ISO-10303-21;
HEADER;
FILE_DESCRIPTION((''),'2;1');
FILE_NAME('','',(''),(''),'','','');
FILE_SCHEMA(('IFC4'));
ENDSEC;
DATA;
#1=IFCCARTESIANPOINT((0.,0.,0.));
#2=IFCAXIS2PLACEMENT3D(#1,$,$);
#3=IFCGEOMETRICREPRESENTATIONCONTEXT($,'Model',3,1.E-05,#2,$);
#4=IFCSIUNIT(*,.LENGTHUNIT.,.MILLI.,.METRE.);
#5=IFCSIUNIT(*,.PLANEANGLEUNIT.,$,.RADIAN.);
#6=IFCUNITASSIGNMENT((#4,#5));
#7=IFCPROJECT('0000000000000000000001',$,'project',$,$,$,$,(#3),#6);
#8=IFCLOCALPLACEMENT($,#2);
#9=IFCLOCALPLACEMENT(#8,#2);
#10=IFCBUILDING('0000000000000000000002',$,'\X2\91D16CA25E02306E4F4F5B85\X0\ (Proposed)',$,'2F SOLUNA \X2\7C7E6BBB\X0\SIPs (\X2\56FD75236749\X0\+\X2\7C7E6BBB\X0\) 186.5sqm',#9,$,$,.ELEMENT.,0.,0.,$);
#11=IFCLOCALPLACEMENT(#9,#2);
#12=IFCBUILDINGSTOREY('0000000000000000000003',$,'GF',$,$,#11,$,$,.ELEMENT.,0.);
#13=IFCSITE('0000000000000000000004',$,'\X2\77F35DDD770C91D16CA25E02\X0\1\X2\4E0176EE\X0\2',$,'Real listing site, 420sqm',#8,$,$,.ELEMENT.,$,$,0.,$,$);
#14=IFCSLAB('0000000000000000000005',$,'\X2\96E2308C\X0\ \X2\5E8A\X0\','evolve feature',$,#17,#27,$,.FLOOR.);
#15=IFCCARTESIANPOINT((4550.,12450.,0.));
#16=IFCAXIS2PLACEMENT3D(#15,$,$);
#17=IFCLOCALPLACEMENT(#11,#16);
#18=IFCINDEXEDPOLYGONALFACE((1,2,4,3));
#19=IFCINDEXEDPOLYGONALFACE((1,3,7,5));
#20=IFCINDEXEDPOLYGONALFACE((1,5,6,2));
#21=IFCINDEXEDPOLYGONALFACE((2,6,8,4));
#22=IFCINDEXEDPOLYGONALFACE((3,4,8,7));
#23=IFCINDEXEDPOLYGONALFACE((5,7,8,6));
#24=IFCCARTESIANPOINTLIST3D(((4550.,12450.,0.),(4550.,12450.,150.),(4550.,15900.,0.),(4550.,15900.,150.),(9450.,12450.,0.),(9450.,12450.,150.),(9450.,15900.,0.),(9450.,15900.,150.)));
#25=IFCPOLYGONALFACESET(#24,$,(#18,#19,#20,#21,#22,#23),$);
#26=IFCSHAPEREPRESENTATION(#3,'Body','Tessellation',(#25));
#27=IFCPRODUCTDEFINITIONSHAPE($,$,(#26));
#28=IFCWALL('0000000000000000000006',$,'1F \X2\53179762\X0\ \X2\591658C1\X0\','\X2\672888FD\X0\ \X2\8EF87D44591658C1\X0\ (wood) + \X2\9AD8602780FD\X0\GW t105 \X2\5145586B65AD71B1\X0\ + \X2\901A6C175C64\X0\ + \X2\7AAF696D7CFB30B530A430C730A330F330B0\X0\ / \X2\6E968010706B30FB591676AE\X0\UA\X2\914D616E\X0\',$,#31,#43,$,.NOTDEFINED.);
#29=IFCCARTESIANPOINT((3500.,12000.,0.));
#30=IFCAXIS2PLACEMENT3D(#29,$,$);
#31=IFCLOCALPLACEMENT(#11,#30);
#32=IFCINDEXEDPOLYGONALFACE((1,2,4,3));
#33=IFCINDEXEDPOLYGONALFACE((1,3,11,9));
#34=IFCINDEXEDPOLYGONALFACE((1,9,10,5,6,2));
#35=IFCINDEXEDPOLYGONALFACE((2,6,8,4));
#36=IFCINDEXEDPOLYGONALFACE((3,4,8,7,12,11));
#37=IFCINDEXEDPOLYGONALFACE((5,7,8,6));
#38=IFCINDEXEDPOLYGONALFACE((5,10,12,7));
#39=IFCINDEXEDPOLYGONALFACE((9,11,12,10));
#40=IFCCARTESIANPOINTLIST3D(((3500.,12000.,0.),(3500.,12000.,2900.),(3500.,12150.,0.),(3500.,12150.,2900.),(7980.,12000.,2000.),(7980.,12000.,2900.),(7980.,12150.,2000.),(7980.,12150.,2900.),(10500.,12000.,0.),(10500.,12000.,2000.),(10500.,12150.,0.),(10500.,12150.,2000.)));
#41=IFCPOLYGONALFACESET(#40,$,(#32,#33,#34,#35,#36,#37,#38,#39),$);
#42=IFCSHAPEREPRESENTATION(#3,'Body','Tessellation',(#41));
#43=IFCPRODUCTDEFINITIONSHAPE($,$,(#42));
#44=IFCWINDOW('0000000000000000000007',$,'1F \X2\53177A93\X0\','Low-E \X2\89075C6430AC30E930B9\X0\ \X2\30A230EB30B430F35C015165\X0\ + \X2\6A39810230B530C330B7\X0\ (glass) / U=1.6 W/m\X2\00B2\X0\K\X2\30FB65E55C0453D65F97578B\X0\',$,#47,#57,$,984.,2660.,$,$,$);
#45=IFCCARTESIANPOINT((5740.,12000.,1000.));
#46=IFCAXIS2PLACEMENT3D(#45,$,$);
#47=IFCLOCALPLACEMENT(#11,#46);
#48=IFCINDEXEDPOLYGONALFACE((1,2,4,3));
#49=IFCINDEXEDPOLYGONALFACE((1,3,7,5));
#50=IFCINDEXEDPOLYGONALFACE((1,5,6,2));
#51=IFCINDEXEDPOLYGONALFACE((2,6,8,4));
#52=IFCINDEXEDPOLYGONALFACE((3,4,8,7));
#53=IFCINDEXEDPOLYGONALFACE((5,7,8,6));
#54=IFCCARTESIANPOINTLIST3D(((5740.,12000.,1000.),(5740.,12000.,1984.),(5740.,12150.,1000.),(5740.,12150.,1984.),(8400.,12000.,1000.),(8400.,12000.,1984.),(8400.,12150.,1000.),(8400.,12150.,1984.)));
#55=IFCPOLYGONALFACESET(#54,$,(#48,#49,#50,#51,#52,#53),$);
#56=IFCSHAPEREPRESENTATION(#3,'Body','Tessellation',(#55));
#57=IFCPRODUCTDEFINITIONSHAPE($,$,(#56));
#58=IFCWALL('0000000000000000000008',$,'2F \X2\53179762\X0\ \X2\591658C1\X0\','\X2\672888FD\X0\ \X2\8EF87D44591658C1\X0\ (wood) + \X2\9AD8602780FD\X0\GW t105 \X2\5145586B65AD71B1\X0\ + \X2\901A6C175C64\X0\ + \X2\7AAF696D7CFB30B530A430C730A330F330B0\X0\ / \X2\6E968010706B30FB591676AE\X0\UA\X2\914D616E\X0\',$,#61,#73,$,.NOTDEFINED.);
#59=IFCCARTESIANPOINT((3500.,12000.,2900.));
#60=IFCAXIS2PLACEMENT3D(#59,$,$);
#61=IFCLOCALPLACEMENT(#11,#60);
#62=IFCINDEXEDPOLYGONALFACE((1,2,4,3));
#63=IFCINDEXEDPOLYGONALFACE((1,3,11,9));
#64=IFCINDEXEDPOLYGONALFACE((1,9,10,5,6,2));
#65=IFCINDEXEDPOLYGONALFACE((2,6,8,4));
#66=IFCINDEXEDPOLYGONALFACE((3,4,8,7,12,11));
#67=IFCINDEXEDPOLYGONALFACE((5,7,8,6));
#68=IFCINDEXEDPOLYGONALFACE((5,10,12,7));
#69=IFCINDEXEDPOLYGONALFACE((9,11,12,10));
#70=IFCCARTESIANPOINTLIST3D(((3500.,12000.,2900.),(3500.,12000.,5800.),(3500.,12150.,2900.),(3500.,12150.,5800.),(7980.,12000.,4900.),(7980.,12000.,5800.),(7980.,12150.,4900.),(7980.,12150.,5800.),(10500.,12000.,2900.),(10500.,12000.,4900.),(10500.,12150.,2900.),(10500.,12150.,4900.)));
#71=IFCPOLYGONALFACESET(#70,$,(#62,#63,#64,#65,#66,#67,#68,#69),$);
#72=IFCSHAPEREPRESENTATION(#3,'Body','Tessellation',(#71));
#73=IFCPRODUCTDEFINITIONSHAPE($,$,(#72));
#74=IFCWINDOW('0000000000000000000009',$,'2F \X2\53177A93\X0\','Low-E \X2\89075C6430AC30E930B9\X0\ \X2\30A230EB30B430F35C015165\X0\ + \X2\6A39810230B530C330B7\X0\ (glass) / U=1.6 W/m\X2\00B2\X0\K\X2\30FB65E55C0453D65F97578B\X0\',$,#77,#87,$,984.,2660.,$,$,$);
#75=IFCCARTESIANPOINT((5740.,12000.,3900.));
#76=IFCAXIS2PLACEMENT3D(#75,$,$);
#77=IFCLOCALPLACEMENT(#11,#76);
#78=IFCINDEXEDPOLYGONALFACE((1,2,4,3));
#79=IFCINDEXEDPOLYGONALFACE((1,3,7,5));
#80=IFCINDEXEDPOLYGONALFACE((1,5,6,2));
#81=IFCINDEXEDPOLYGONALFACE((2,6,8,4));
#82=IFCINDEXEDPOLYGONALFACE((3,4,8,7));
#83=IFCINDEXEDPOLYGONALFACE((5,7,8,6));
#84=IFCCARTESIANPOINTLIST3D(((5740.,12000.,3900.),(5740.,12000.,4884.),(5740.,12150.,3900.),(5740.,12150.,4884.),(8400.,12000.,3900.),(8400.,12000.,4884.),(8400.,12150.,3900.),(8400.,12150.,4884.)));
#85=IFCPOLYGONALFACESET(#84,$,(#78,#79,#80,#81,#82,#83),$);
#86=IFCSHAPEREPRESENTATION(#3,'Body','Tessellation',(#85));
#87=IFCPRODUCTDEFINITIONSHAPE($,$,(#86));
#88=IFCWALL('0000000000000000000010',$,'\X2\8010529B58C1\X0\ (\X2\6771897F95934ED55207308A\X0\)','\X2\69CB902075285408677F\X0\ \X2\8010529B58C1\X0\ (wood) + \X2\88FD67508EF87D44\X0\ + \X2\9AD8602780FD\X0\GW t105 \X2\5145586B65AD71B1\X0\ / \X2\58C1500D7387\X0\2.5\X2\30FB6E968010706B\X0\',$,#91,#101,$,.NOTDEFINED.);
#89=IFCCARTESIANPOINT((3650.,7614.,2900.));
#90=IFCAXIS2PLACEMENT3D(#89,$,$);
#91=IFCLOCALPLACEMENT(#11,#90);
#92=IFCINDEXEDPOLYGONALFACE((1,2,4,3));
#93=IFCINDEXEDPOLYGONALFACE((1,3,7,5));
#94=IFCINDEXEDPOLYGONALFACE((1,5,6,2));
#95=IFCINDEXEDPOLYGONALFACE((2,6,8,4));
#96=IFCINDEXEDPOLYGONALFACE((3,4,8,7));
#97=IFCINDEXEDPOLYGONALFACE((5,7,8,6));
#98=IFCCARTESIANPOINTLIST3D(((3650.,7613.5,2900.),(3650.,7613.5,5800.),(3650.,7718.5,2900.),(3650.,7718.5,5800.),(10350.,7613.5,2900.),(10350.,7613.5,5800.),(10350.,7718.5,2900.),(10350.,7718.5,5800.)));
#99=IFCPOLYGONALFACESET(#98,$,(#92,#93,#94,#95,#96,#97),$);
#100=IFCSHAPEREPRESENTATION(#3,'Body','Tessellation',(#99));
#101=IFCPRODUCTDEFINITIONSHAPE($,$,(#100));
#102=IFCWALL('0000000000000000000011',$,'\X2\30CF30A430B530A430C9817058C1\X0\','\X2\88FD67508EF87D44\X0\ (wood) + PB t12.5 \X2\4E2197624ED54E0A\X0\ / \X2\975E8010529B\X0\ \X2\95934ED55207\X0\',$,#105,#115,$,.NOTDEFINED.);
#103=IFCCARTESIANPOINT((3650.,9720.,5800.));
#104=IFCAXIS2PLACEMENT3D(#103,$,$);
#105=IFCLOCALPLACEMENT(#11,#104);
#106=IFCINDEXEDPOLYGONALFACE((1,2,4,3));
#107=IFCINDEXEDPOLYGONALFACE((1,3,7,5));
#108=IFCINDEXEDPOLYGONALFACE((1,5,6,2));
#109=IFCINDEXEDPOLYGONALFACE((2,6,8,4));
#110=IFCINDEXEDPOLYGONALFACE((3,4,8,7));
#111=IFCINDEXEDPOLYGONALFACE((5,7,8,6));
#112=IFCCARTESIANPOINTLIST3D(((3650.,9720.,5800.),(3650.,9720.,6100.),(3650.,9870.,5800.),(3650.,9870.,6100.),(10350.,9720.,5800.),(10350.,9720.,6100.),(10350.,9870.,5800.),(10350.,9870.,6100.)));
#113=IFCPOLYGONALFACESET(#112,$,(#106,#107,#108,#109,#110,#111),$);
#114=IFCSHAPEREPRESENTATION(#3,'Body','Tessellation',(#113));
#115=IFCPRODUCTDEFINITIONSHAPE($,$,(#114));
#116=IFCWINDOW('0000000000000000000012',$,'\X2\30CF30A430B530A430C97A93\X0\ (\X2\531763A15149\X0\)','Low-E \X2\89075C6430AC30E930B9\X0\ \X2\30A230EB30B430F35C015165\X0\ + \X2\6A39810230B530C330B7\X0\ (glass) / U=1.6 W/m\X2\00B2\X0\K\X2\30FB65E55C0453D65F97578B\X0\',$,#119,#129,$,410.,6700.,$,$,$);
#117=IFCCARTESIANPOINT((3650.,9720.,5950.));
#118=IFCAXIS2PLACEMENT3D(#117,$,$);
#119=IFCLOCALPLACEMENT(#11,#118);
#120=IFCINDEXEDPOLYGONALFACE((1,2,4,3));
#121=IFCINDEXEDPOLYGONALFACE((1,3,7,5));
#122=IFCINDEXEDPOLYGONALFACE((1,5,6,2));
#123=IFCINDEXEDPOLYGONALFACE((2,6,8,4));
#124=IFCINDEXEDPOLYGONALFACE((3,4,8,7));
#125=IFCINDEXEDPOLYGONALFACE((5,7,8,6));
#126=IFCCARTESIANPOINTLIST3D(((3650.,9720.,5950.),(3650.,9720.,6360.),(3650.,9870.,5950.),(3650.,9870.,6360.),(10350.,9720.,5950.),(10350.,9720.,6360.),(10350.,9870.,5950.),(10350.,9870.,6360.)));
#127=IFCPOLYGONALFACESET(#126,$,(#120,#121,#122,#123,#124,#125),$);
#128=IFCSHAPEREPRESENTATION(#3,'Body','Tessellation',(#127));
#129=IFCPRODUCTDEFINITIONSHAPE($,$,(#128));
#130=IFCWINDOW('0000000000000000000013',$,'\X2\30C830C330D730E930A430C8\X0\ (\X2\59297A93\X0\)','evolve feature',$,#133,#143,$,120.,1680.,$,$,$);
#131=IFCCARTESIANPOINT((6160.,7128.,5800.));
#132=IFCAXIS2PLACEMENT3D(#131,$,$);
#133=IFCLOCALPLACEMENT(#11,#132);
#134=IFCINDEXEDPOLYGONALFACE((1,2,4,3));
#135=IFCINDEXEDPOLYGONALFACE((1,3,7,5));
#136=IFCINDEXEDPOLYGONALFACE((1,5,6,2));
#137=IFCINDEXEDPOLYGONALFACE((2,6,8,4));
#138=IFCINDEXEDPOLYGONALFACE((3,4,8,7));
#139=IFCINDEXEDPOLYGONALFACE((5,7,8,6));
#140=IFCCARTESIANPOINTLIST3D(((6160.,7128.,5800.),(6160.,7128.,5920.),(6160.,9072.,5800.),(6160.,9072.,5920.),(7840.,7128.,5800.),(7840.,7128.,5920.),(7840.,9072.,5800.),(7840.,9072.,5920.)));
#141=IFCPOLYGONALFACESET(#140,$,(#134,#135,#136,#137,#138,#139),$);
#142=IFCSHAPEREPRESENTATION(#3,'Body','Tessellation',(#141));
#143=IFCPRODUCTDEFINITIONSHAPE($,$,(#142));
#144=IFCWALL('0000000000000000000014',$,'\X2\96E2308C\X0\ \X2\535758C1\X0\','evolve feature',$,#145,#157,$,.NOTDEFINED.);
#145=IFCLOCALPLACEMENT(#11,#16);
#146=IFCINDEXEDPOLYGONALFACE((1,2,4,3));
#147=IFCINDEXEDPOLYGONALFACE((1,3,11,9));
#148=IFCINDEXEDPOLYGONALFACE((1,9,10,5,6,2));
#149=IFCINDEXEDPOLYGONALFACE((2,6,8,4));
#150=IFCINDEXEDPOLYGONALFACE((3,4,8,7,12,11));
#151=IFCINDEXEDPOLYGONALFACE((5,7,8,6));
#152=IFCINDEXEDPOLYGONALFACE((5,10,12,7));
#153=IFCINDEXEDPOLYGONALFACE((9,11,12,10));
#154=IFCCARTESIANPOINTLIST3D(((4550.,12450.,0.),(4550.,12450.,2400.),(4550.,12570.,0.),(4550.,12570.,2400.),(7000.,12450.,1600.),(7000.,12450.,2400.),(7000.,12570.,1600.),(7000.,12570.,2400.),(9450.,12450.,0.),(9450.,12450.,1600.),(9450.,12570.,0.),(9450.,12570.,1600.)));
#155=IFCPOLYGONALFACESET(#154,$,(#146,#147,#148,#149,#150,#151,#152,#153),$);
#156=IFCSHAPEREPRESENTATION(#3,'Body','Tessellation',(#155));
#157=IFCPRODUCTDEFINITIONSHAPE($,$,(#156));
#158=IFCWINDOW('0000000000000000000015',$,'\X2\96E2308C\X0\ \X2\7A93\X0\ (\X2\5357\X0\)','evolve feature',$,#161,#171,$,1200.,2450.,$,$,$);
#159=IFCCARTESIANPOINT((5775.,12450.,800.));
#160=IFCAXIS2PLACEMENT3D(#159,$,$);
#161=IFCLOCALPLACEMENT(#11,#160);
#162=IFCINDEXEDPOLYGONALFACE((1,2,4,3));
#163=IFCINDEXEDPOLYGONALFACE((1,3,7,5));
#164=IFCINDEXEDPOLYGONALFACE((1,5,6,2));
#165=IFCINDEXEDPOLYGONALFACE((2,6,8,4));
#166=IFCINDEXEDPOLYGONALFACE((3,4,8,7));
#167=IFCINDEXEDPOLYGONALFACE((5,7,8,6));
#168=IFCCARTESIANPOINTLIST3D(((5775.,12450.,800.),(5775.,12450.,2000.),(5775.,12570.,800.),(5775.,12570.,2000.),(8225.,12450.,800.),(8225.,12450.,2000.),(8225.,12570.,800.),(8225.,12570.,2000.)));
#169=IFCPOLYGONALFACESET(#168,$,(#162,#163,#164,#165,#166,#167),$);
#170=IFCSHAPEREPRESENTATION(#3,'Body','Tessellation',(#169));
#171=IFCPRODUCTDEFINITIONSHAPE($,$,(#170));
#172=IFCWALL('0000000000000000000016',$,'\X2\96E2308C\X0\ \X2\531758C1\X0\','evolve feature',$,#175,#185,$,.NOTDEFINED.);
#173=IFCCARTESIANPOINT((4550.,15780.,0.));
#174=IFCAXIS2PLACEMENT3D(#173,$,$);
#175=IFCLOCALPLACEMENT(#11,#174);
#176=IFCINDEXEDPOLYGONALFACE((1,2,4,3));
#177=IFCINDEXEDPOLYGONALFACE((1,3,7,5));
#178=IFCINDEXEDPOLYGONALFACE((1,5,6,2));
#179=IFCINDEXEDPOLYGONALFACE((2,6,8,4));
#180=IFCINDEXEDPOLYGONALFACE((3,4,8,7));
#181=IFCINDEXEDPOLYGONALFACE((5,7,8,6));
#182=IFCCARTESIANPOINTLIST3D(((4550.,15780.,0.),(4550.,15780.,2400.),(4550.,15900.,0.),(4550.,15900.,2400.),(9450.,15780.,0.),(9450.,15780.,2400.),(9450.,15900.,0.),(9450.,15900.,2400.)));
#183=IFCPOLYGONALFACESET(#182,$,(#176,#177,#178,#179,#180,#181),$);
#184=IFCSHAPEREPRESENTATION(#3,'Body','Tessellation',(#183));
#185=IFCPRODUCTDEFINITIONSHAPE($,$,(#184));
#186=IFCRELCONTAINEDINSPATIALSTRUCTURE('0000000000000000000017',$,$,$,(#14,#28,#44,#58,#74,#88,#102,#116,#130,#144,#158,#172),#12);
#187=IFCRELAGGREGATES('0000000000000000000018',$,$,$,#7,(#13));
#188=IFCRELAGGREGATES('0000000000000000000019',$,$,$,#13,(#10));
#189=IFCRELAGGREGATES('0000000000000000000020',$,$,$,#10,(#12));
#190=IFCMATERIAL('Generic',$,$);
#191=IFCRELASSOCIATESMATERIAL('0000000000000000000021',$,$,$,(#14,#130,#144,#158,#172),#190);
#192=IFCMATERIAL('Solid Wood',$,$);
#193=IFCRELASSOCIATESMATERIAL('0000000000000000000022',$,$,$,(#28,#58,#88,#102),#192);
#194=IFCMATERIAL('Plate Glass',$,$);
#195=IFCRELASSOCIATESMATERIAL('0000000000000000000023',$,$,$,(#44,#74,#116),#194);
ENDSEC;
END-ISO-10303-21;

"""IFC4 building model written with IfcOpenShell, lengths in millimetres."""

from ifc_helpers import new_model, si_unit, frame, frame_2d, origin, place, context, project, spatial, rectangle, extrude, material, element, fill, save


model = new_model("IFC4")

# Units and contexts
model_context = context("Model", 3, precision=1e-05, world=origin())
ifc_project = project(units=[si_unit("LENGTHUNIT", "METRE", prefix="MILLI"), si_unit("PLANEANGLEUNIT", "RADIAN")], contexts=[model_context])

# Site, building, storey
site_placement = place(None, origin())
site = spatial("IfcSite", under=ifc_project, at=site_placement, Name="石川県金沢市1丁目2", ObjectType="Real listing site, 420sqm", CompositionType="ELEMENT", RefElevation=0.0)
building_placement = place(site_placement, origin())
building = spatial("IfcBuilding", under=site, at=building_placement, Name="金沢市の住宅 (Proposed)", ObjectType="2F SOLUNA 籾殻SIPs (国産杉+籾殻) 186.5sqm", CompositionType="ELEMENT", ElevationOfRefHeight=0.0, ElevationOfTerrain=0.0)
storey_placement = place(building_placement, origin())
storey = spatial("IfcBuildingStorey", under=building, at=storey_placement, Name="GF", CompositionType="ELEMENT", Elevation=0.0)

# Slab
ifc_material_1 = material(Name="Generic")
slab_placement = place(storey_placement, frame((4550.0, 12450.0, 0.0)))
element("IfcSlab", 1, at=slab_placement, inside=storey, material=ifc_material_1, Name="離れ 床", Description="evolve feature", PredefinedType="FLOOR", context=model_context, shape_type="SweptSolid", body=[
    extrude(rectangle(XDim=4900.0, YDim=3450.0, at=frame_2d((2450.0, 1725.0))), frame((4550.0, 12450.0, 0.0)), (0.0, 0.0, 1.0), 150.0),
])

# Wall, opening, window
ifc_material_2 = material(Name="Solid Wood")
wall_1_placement = place(storey_placement, frame((3500.0, 12000.0, 0.0)))
wall_1 = element("IfcWall", 2, at=wall_1_placement, inside=storey, material=ifc_material_2, Name="1F 北面 外壁", Description="木製 軸組外壁 (wood) + 高性能GW t105 充填断熱 + 通気層 + 窯業系サイディング / 準耐火・外皮UA配慮", PredefinedType="NOTDEFINED", context=model_context, shape_type="SweptSolid", body=[
    extrude(rectangle(XDim=7000.0, YDim=150.0, at=frame_2d((3500.0, 75.0))), frame((3500.0, 12000.0, 0.0)), (0.0, 0.0, 1.0), 2900.0),
])
opening_1_placement = place(storey_placement, frame((5740.0, 12000.0, 1000.0)))
opening_1 = element("IfcOpeningElement", 3, at=opening_1_placement, cuts=wall_1, PredefinedType="NOTDEFINED", context=model_context, shape_type="SweptSolid", body=[
    extrude(rectangle(XDim=2660.0, YDim=150.0, at=frame_2d((1330.0, 75.0))), frame((5740.0, 12000.0, 1000.0)), (0.0, 0.0, 1.0), 984.0),
])
ifc_material_3 = material(Name="Plate Glass")
window_1_placement = place(storey_placement, frame((5740.0, 12000.0, 1000.0)))
window_1 = element("IfcWindow", 4, at=window_1_placement, inside=storey, material=ifc_material_3, Name="1F 北窓", Description="Low-E 複層ガラス アルゴン封入 + 樹脂サッシ (glass) / U=1.6 W/m²K・日射取得型", OverallHeight=984.0, OverallWidth=2660.0, context=model_context, shape_type="SweptSolid", body=[
    extrude(rectangle(XDim=2660.0, YDim=150.0, at=frame_2d((1330.0, 75.0))), frame((5740.0, 12000.0, 1000.0)), (0.0, 0.0, 1.0), 984.0),
])
fill(opening_1, window_1)

# Wall, opening, window
wall_2_placement = place(storey_placement, frame((3500.0, 12000.0, 2900.0)))
wall_2 = element("IfcWall", 5, at=wall_2_placement, inside=storey, material=ifc_material_2, Name="2F 北面 外壁", Description="木製 軸組外壁 (wood) + 高性能GW t105 充填断熱 + 通気層 + 窯業系サイディング / 準耐火・外皮UA配慮", PredefinedType="NOTDEFINED", context=model_context, shape_type="SweptSolid", body=[
    extrude(rectangle(XDim=7000.0, YDim=150.0, at=frame_2d((3500.0, 75.0))), frame((3500.0, 12000.0, 2900.0)), (0.0, 0.0, 1.0), 2900.0),
])
opening_2_placement = place(storey_placement, frame((5740.0, 12000.0, 3900.0)))
opening_2 = element("IfcOpeningElement", 6, at=opening_2_placement, cuts=wall_2, PredefinedType="NOTDEFINED", context=model_context, shape_type="SweptSolid", body=[
    extrude(rectangle(XDim=2660.0, YDim=150.0, at=frame_2d((1330.0, 75.0))), frame((5740.0, 12000.0, 3900.0)), (0.0, 0.0, 1.0), 984.0),
])
window_2_placement = place(storey_placement, frame((5740.0, 12000.0, 3900.0)))
window_2 = element("IfcWindow", 7, at=window_2_placement, inside=storey, material=ifc_material_3, Name="2F 北窓", Description="Low-E 複層ガラス アルゴン封入 + 樹脂サッシ (glass) / U=1.6 W/m²K・日射取得型", OverallHeight=984.0, OverallWidth=2660.0, context=model_context, shape_type="SweptSolid", body=[
    extrude(rectangle(XDim=2660.0, YDim=150.0, at=frame_2d((1330.0, 75.0))), frame((5740.0, 12000.0, 3900.0)), (0.0, 0.0, 1.0), 984.0),
])
fill(opening_2, window_2)

# Wall
wall_3_placement = place(storey_placement, frame((3650.0, 7614.0, 2900.0)))
element("IfcWall", 8, at=wall_3_placement, inside=storey, material=ifc_material_2, Name="耐力壁 (東西間仕切り)", Description="構造用合板 耐力壁 (wood) + 製材軸組 + 高性能GW t105 充填断熱 / 壁倍率2.5・準耐火", PredefinedType="NOTDEFINED", context=model_context, shape_type="SweptSolid", body=[
    extrude(rectangle(XDim=6700.0, YDim=105.0, at=frame_2d((3350.0, 52.0))), frame((3650.0, 7614.0, 2900.0)), (0.0, 0.0, 1.0), 2900.0),
])

# Wall, opening, window
wall_4_placement = place(storey_placement, frame((3650.0, 9720.0, 5800.0)))
wall_4 = element("IfcWall", 9, at=wall_4_placement, inside=storey, material=ifc_material_2, Name="ハイサイド腰壁", Description="製材軸組 (wood) + PB t12.5 両面仕上 / 非耐力 間仕切", PredefinedType="NOTDEFINED", context=model_context, shape_type="SweptSolid", body=[
    extrude(rectangle(XDim=6700.0, YDim=150.0, at=frame_2d((3350.0, 75.0))), frame((3650.0, 9720.0, 5800.0)), (0.0, 0.0, 1.0), 700.0),
])
opening_3_placement = place(storey_placement, frame((3650.0, 9720.0, 5950.0)))
opening_3 = element("IfcOpeningElement", 10, at=opening_3_placement, cuts=wall_4, PredefinedType="NOTDEFINED", context=model_context, shape_type="SweptSolid", body=[
    extrude(rectangle(XDim=6700.0, YDim=150.0, at=frame_2d((3350.0, 75.0))), frame((3650.0, 9720.0, 5950.0)), (0.0, 0.0, 1.0), 410.0),
])
window_3_placement = place(storey_placement, frame((3650.0, 9720.0, 5950.0)))
window_3 = element("IfcWindow", 11, at=window_3_placement, inside=storey, material=ifc_material_3, Name="ハイサイド窓 (北採光)", Description="Low-E 複層ガラス アルゴン封入 + 樹脂サッシ (glass) / U=1.6 W/m²K・日射取得型", OverallHeight=410.0, OverallWidth=6700.0, context=model_context, shape_type="SweptSolid", body=[
    extrude(rectangle(XDim=6700.0, YDim=150.0, at=frame_2d((3350.0, 75.0))), frame((3650.0, 9720.0, 5950.0)), (0.0, 0.0, 1.0), 410.0),
])
fill(opening_3, window_3)

# Window
window_4_placement = place(storey_placement, frame((6160.0, 7128.0, 5800.0)))
element("IfcWindow", 12, at=window_4_placement, inside=storey, material=ifc_material_1, Name="トップライト (天窓)", Description="evolve feature", OverallHeight=120.0, OverallWidth=1680.0, context=model_context, shape_type="SweptSolid", body=[
    extrude(rectangle(XDim=1680.0, YDim=1944.0, at=frame_2d((840.0, 972.0))), frame((6160.0, 7128.0, 5800.0)), (0.0, 0.0, 1.0), 120.0),
])

# Wall, opening, window
wall_5_placement = place(storey_placement, frame((4550.0, 12450.0, 0.0)))
wall_5 = element("IfcWall", 13, at=wall_5_placement, inside=storey, material=ifc_material_1, Name="離れ 南壁", Description="evolve feature", PredefinedType="NOTDEFINED", context=model_context, shape_type="SweptSolid", body=[
    extrude(rectangle(XDim=4900.0, YDim=120.0, at=frame_2d((2450.0, 60.0))), frame((4550.0, 12450.0, 0.0)), (0.0, 0.0, 1.0), 2400.0),
])
opening_4_placement = place(storey_placement, frame((5775.0, 12450.0, 800.0)))
opening_4 = element("IfcOpeningElement", 14, at=opening_4_placement, cuts=wall_5, PredefinedType="NOTDEFINED", context=model_context, shape_type="SweptSolid", body=[
    extrude(rectangle(XDim=2450.0, YDim=120.0, at=frame_2d((1225.0, 60.0))), frame((5775.0, 12450.0, 800.0)), (0.0, 0.0, 1.0), 1200.0),
])
window_5_placement = place(storey_placement, frame((5775.0, 12450.0, 800.0)))
window_5 = element("IfcWindow", 15, at=window_5_placement, inside=storey, material=ifc_material_1, Name="離れ 窓 (南)", Description="evolve feature", OverallHeight=1200.0, OverallWidth=2450.0, context=model_context, shape_type="SweptSolid", body=[
    extrude(rectangle(XDim=2450.0, YDim=120.0, at=frame_2d((1225.0, 60.0))), frame((5775.0, 12450.0, 800.0)), (0.0, 0.0, 1.0), 1200.0),
])
fill(opening_4, window_5)

# Wall
wall_6_placement = place(storey_placement, frame((4550.0, 15780.0, 0.0)))
element("IfcWall", 16, at=wall_6_placement, inside=storey, material=ifc_material_1, Name="離れ 北壁", Description="evolve feature", PredefinedType="NOTDEFINED", context=model_context, shape_type="SweptSolid", body=[
    extrude(rectangle(XDim=4900.0, YDim=120.0, at=frame_2d((2450.0, 60.0))), frame((4550.0, 15780.0, 0.0)), (0.0, 0.0, 1.0), 2400.0),
])

save(model, "model.ifc")
